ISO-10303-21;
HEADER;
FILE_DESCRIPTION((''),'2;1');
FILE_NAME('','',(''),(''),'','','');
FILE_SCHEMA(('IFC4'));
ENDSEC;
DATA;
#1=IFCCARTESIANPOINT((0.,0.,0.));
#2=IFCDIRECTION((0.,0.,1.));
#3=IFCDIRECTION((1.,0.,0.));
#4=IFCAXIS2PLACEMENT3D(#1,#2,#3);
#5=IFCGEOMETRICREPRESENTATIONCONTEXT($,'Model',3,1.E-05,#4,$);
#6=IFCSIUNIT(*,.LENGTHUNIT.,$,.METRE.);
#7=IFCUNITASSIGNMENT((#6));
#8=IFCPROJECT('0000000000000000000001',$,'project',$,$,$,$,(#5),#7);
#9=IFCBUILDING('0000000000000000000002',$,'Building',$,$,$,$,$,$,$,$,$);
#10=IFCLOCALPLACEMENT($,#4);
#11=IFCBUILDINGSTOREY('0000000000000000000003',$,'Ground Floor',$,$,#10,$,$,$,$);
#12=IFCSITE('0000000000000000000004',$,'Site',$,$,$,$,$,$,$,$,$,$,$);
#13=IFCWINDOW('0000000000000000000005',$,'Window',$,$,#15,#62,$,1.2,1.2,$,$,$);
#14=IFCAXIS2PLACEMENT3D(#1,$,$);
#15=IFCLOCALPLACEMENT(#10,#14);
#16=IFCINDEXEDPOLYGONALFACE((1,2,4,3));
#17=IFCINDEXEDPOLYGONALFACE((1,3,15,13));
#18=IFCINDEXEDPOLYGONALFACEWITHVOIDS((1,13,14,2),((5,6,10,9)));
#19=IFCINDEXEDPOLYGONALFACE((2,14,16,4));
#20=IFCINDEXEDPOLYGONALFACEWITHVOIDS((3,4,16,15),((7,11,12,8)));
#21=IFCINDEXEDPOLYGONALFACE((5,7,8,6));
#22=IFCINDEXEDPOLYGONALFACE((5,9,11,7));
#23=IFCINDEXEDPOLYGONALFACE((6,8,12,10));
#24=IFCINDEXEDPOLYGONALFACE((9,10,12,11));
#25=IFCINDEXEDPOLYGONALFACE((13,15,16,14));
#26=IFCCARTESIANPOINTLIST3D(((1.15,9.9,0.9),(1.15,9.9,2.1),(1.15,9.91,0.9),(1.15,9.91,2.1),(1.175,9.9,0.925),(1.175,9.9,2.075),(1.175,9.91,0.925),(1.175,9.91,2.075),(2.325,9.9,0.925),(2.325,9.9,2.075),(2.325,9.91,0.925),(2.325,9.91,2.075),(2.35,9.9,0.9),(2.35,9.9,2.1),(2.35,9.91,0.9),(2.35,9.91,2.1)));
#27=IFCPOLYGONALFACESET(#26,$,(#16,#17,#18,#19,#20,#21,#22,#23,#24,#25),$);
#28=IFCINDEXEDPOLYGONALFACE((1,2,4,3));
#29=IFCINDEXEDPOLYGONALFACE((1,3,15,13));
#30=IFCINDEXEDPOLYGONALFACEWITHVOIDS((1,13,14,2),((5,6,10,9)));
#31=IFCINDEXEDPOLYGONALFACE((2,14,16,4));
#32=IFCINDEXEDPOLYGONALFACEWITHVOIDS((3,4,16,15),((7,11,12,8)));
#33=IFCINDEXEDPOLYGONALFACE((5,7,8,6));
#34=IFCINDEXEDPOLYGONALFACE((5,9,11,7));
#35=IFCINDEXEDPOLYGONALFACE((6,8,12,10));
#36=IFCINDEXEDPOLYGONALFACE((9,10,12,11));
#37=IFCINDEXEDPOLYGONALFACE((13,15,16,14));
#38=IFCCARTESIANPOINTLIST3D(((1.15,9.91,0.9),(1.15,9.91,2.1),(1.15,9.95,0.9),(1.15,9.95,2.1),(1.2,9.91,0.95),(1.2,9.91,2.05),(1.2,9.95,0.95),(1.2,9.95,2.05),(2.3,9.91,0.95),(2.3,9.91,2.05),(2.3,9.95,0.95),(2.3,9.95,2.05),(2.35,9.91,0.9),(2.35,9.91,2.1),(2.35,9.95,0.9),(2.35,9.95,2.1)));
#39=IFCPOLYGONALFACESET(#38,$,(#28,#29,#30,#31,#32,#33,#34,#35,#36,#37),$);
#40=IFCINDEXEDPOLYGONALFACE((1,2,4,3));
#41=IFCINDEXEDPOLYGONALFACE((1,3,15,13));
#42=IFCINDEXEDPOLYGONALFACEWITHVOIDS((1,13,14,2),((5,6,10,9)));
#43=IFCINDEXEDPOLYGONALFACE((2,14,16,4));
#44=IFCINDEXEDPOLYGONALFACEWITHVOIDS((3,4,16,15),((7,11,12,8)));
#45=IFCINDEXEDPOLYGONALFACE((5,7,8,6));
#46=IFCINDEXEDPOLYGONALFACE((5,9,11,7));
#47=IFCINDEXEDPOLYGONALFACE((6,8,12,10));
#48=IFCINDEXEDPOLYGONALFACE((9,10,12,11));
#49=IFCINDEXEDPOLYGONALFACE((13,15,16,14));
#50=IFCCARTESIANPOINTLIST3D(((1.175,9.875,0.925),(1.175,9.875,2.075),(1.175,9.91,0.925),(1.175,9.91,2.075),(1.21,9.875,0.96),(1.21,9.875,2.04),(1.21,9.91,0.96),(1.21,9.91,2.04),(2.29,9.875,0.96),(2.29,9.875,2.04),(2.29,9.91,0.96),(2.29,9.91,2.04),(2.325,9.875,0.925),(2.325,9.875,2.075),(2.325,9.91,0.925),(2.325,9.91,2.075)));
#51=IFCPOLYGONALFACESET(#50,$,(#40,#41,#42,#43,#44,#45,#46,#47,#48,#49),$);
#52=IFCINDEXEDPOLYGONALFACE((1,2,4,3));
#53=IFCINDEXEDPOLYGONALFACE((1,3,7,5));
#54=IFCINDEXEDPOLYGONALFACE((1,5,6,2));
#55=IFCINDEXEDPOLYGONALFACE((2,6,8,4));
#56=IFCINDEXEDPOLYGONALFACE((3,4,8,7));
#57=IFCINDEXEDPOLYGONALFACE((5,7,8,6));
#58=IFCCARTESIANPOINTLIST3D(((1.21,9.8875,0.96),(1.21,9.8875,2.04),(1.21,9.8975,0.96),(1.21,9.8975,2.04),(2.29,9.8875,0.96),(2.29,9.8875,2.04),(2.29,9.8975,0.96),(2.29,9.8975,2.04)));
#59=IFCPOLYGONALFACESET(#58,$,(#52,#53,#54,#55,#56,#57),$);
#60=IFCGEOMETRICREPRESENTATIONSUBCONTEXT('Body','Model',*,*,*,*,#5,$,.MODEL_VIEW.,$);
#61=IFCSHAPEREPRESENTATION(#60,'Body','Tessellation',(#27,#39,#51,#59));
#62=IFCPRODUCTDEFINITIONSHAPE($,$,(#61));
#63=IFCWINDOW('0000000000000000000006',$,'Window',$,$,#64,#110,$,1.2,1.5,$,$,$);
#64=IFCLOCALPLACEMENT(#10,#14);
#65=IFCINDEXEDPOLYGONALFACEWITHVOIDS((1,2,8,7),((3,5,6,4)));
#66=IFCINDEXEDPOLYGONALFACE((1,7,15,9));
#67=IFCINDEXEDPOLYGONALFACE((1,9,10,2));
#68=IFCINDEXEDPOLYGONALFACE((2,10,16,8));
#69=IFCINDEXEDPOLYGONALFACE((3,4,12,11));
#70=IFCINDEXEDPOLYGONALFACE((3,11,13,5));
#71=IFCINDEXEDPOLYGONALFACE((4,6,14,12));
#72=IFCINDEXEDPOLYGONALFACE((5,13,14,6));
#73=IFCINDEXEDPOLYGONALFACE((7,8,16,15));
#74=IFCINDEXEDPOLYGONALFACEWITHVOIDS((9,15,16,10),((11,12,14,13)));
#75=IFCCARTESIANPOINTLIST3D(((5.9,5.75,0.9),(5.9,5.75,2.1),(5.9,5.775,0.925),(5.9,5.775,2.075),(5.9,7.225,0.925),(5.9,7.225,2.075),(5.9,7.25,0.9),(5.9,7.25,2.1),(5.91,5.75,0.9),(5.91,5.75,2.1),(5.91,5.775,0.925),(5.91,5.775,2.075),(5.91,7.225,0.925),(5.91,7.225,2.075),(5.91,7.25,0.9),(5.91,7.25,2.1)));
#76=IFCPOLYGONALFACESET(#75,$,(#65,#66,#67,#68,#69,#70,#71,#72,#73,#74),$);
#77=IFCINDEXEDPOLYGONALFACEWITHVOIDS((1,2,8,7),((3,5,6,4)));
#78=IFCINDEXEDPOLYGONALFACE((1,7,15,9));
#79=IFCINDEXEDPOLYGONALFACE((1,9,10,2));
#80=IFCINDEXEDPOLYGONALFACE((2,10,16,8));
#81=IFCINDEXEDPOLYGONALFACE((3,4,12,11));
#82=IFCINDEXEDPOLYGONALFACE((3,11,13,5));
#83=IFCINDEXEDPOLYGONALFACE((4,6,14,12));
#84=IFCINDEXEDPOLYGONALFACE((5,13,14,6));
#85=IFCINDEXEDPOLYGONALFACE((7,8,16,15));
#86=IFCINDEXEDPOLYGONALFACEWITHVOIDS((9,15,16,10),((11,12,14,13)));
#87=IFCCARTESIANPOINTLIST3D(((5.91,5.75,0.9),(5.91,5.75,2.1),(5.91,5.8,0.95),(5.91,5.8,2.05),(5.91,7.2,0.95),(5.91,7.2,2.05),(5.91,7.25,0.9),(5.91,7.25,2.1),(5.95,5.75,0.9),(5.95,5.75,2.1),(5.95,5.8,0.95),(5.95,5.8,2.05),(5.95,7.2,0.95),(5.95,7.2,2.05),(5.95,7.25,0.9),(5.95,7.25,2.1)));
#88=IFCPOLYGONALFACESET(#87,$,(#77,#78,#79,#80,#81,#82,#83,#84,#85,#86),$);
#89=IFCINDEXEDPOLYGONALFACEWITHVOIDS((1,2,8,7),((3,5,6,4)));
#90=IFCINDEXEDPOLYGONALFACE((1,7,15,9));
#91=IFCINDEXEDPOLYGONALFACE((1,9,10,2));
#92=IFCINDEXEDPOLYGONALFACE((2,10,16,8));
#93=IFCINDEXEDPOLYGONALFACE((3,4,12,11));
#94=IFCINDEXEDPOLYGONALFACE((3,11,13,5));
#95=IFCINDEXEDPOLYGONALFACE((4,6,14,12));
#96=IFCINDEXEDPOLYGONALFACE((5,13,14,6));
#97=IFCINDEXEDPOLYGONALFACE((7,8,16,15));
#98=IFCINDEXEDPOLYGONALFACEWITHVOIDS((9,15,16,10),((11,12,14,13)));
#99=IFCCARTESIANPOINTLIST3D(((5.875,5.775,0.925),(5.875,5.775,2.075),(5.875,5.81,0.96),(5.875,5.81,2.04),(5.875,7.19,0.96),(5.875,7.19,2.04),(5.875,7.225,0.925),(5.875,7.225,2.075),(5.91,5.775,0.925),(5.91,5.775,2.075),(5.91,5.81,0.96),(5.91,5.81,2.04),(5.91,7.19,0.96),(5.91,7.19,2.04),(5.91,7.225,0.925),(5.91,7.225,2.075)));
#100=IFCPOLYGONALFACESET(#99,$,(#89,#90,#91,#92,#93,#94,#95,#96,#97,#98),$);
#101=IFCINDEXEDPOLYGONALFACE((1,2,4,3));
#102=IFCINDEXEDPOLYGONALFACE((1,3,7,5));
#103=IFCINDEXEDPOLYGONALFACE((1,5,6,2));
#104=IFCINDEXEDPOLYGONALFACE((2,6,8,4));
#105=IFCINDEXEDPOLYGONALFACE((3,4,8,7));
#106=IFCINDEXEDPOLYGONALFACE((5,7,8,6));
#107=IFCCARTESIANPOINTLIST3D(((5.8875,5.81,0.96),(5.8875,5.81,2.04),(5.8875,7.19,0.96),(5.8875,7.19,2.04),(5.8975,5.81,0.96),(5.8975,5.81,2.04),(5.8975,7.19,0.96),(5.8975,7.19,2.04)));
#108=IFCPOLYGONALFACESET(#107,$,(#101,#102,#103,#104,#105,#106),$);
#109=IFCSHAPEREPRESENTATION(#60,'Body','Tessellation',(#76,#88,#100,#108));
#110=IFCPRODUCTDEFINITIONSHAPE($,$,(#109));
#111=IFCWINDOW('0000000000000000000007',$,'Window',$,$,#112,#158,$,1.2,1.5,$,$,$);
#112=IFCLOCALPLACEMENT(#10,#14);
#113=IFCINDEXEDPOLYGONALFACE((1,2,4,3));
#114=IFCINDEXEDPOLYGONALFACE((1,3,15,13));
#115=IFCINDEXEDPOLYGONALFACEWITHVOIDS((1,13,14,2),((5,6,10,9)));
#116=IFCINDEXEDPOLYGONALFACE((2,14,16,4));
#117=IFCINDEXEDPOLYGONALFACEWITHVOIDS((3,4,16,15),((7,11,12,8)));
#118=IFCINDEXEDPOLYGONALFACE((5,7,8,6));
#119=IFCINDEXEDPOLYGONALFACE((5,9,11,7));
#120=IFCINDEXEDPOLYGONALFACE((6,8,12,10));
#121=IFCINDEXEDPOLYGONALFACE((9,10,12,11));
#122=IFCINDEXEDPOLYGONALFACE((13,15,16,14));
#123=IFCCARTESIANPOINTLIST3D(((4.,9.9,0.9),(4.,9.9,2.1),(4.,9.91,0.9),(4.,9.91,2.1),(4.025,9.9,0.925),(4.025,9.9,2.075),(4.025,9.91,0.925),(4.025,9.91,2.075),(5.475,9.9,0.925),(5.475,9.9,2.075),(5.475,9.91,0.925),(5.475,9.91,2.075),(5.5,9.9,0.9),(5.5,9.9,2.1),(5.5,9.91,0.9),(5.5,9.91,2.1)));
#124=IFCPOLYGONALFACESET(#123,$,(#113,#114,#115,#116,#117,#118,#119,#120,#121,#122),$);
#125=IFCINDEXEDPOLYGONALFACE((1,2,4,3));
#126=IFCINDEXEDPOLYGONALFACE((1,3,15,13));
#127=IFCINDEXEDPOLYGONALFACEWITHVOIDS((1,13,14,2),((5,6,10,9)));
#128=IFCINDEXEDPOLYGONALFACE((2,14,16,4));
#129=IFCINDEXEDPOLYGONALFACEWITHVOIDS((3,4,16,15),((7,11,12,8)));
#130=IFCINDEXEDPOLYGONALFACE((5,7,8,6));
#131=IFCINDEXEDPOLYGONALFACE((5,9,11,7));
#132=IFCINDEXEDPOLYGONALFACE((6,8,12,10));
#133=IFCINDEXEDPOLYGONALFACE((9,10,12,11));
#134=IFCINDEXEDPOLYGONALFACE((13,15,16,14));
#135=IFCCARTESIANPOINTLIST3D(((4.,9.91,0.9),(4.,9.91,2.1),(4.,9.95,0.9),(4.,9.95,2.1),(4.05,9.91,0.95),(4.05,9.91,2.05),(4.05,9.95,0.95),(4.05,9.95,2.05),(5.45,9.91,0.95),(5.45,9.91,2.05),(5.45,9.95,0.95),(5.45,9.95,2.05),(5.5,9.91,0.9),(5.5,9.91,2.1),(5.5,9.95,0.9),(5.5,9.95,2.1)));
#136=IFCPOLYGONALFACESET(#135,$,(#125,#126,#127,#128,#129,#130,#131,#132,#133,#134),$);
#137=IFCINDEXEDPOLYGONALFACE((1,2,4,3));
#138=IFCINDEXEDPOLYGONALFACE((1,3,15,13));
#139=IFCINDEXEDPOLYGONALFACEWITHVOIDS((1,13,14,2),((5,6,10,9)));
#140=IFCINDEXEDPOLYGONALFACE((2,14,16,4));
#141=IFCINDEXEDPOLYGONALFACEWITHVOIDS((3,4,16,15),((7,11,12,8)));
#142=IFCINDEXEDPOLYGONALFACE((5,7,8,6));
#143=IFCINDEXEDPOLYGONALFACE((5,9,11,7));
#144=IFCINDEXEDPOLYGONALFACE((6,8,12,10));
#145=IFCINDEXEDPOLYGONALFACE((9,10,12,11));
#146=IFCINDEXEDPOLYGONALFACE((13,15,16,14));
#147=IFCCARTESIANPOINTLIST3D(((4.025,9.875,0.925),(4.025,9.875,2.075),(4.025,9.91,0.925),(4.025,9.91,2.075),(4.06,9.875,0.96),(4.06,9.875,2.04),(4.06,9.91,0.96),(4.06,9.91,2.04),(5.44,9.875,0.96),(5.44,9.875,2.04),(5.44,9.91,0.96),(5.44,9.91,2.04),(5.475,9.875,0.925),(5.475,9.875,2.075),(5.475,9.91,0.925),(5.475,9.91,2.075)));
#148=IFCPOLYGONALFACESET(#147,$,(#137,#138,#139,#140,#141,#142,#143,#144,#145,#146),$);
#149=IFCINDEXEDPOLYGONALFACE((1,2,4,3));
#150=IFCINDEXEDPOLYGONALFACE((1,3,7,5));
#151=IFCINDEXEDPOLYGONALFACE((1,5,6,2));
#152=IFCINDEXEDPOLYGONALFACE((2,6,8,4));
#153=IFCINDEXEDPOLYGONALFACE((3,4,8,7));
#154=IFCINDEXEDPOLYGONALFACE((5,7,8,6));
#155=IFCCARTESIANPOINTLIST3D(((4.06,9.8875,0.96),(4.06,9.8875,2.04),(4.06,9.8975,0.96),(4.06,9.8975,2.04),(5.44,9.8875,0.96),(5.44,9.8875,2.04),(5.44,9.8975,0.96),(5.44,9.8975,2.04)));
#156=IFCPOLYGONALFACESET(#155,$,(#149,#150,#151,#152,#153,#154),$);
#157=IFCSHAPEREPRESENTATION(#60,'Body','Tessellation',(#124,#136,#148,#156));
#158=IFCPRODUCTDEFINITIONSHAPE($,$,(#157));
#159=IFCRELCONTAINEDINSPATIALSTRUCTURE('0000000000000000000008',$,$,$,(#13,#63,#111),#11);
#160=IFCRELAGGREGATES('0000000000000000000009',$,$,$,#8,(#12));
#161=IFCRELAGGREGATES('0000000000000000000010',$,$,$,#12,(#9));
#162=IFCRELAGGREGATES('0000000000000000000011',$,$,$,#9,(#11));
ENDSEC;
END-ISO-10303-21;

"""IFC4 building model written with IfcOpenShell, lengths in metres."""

from ifc_helpers import new_model, si_unit, frame, origin_with_axes, place, context, subcontext, project, spatial, line, indexed_curve, outline, extrude, element, save


model = new_model("IFC4")

# Units and contexts
model_context = context("Model", 3, precision=1e-05, world=origin_with_axes())
body_context = subcontext(model_context, "Body", "Model", "MODEL_VIEW")
ifc_project = project(units=[si_unit("LENGTHUNIT", "METRE")], contexts=[model_context])

# Site, building, storey
site = spatial("IfcSite", under=ifc_project, Name="Site")
building = spatial("IfcBuilding", under=site, Name="Building")
storey_placement = place(None, origin_with_axes())
storey = spatial("IfcBuildingStorey", under=building, at=storey_placement, Name="Ground Floor")

# Windows
window_1_placement = place(storey_placement, frame((2.35, 10.0, 0.9), z_axis=(0.0, 0.0, 1.0), x_axis=(-1.0, 0.0, 0.0)))
element("IfcWindow", 1, at=window_1_placement, inside=storey, Name="Window", OverallHeight=1.2, OverallWidth=1.2, context=body_context, shape_type="SweptSolid", body=[
    extrude(outline(indexed_curve([(0.0, 0.0), (1.2, 0.0), (1.2, 1.2), (0.0, 1.2)], segments=[line(1, 2, 3, 4, 1)]), holes=[indexed_curve([(0.025, 0.025), (1.175, 0.025), (1.175, 1.175), (0.025, 1.175)], segments=[line(1, 2, 3, 4, 1)])]), frame((0.0, 0.09, 0.0), z_axis=(0.0, -1.0, 0.0), x_axis=(1.0, 0.0, 0.0)), (0.0, 0.0, -1.0), 0.01),
    extrude(outline(indexed_curve([(0.0, 0.0), (1.2, 0.0), (1.2, 1.2), (0.0, 1.2)], segments=[line(1, 2, 3, 4, 1)]), holes=[indexed_curve([(0.05, 0.05), (1.15, 0.05), (1.15, 1.15), (0.05, 1.15)], segments=[line(1, 2, 3, 4, 1)])]), frame((0.0, 0.05, 0.0), z_axis=(0.0, -1.0, 0.0), x_axis=(1.0, 0.0, 0.0)), (0.0, 0.0, -1.0), 0.04),
    extrude(outline(indexed_curve([(0.0, 0.0), (1.15, 0.0), (1.15, 1.15), (0.0, 1.15)], segments=[line(1, 2, 3, 4, 1)]), holes=[indexed_curve([(0.035, 0.035), (1.115, 0.035), (1.115, 1.115), (0.035, 1.115)], segments=[line(1, 2, 3, 4, 1)])]), frame((0.025, 0.09, 0.025), z_axis=(0.0, -1.0, 0.0), x_axis=(1.0, 0.0, 0.0)), (0.0, 0.0, -1.0), 0.035),
    extrude(outline(indexed_curve([(0.035, 0.035), (1.115, 0.035), (1.115, 1.115), (0.035, 1.115)], segments=[line(1, 2, 3, 4, 1)])), frame((0.025, 0.1025, 0.025), z_axis=(0.0, -1.0, 0.0), x_axis=(1.0, 0.0, 0.0)), (0.0, 0.0, -1.0), 0.01),
])
for number, where, z_axis, x_axis, name in (
    (2, (6.0, 5.75, 0.9), (0.0, 0.0, 1.0), (0.0, 1.0, 0.0), "Window"),
    (3, (5.5, 10.0, 0.9), (0.0, 0.0, 1.0), (-1.0, 0.0, 0.0), "Window"),
):
    element("IfcWindow", number, at=place(storey_placement, frame(where, z_axis=z_axis, x_axis=x_axis)), inside=storey, Name=name, OverallHeight=1.2, OverallWidth=1.5, context=body_context, shape_type="SweptSolid", body=[
        extrude(outline(indexed_curve([(0.0, 0.0), (1.5, 0.0), (1.5, 1.2), (0.0, 1.2)], segments=[line(1, 2, 3, 4, 1)]), holes=[indexed_curve([(0.025, 0.025), (1.475, 0.025), (1.475, 1.175), (0.025, 1.175)], segments=[line(1, 2, 3, 4, 1)])]), frame((0.0, 0.09, 0.0), z_axis=(0.0, -1.0, 0.0), x_axis=(1.0, 0.0, 0.0)), (0.0, 0.0, -1.0), 0.01),
        extrude(outline(indexed_curve([(0.0, 0.0), (1.5, 0.0), (1.5, 1.2), (0.0, 1.2)], segments=[line(1, 2, 3, 4, 1)]), holes=[indexed_curve([(0.05, 0.05), (1.45, 0.05), (1.45, 1.15), (0.05, 1.15)], segments=[line(1, 2, 3, 4, 1)])]), frame((0.0, 0.05, 0.0), z_axis=(0.0, -1.0, 0.0), x_axis=(1.0, 0.0, 0.0)), (0.0, 0.0, -1.0), 0.04),
        extrude(outline(indexed_curve([(0.0, 0.0), (1.45, 0.0), (1.45, 1.15), (0.0, 1.15)], segments=[line(1, 2, 3, 4, 1)]), holes=[indexed_curve([(0.035, 0.035), (1.415, 0.035), (1.415, 1.115), (0.035, 1.115)], segments=[line(1, 2, 3, 4, 1)])]), frame((0.025, 0.09, 0.025), z_axis=(0.0, -1.0, 0.0), x_axis=(1.0, 0.0, 0.0)), (0.0, 0.0, -1.0), 0.035),
        extrude(outline(indexed_curve([(0.035, 0.035), (1.415, 0.035), (1.415, 1.115), (0.035, 1.115)], segments=[line(1, 2, 3, 4, 1)])), frame((0.025, 0.1025, 0.025), z_axis=(0.0, -1.0, 0.0), x_axis=(1.0, 0.0, 0.0)), (0.0, 0.0, -1.0), 0.01),
    ])

save(model, "model.ifc")
